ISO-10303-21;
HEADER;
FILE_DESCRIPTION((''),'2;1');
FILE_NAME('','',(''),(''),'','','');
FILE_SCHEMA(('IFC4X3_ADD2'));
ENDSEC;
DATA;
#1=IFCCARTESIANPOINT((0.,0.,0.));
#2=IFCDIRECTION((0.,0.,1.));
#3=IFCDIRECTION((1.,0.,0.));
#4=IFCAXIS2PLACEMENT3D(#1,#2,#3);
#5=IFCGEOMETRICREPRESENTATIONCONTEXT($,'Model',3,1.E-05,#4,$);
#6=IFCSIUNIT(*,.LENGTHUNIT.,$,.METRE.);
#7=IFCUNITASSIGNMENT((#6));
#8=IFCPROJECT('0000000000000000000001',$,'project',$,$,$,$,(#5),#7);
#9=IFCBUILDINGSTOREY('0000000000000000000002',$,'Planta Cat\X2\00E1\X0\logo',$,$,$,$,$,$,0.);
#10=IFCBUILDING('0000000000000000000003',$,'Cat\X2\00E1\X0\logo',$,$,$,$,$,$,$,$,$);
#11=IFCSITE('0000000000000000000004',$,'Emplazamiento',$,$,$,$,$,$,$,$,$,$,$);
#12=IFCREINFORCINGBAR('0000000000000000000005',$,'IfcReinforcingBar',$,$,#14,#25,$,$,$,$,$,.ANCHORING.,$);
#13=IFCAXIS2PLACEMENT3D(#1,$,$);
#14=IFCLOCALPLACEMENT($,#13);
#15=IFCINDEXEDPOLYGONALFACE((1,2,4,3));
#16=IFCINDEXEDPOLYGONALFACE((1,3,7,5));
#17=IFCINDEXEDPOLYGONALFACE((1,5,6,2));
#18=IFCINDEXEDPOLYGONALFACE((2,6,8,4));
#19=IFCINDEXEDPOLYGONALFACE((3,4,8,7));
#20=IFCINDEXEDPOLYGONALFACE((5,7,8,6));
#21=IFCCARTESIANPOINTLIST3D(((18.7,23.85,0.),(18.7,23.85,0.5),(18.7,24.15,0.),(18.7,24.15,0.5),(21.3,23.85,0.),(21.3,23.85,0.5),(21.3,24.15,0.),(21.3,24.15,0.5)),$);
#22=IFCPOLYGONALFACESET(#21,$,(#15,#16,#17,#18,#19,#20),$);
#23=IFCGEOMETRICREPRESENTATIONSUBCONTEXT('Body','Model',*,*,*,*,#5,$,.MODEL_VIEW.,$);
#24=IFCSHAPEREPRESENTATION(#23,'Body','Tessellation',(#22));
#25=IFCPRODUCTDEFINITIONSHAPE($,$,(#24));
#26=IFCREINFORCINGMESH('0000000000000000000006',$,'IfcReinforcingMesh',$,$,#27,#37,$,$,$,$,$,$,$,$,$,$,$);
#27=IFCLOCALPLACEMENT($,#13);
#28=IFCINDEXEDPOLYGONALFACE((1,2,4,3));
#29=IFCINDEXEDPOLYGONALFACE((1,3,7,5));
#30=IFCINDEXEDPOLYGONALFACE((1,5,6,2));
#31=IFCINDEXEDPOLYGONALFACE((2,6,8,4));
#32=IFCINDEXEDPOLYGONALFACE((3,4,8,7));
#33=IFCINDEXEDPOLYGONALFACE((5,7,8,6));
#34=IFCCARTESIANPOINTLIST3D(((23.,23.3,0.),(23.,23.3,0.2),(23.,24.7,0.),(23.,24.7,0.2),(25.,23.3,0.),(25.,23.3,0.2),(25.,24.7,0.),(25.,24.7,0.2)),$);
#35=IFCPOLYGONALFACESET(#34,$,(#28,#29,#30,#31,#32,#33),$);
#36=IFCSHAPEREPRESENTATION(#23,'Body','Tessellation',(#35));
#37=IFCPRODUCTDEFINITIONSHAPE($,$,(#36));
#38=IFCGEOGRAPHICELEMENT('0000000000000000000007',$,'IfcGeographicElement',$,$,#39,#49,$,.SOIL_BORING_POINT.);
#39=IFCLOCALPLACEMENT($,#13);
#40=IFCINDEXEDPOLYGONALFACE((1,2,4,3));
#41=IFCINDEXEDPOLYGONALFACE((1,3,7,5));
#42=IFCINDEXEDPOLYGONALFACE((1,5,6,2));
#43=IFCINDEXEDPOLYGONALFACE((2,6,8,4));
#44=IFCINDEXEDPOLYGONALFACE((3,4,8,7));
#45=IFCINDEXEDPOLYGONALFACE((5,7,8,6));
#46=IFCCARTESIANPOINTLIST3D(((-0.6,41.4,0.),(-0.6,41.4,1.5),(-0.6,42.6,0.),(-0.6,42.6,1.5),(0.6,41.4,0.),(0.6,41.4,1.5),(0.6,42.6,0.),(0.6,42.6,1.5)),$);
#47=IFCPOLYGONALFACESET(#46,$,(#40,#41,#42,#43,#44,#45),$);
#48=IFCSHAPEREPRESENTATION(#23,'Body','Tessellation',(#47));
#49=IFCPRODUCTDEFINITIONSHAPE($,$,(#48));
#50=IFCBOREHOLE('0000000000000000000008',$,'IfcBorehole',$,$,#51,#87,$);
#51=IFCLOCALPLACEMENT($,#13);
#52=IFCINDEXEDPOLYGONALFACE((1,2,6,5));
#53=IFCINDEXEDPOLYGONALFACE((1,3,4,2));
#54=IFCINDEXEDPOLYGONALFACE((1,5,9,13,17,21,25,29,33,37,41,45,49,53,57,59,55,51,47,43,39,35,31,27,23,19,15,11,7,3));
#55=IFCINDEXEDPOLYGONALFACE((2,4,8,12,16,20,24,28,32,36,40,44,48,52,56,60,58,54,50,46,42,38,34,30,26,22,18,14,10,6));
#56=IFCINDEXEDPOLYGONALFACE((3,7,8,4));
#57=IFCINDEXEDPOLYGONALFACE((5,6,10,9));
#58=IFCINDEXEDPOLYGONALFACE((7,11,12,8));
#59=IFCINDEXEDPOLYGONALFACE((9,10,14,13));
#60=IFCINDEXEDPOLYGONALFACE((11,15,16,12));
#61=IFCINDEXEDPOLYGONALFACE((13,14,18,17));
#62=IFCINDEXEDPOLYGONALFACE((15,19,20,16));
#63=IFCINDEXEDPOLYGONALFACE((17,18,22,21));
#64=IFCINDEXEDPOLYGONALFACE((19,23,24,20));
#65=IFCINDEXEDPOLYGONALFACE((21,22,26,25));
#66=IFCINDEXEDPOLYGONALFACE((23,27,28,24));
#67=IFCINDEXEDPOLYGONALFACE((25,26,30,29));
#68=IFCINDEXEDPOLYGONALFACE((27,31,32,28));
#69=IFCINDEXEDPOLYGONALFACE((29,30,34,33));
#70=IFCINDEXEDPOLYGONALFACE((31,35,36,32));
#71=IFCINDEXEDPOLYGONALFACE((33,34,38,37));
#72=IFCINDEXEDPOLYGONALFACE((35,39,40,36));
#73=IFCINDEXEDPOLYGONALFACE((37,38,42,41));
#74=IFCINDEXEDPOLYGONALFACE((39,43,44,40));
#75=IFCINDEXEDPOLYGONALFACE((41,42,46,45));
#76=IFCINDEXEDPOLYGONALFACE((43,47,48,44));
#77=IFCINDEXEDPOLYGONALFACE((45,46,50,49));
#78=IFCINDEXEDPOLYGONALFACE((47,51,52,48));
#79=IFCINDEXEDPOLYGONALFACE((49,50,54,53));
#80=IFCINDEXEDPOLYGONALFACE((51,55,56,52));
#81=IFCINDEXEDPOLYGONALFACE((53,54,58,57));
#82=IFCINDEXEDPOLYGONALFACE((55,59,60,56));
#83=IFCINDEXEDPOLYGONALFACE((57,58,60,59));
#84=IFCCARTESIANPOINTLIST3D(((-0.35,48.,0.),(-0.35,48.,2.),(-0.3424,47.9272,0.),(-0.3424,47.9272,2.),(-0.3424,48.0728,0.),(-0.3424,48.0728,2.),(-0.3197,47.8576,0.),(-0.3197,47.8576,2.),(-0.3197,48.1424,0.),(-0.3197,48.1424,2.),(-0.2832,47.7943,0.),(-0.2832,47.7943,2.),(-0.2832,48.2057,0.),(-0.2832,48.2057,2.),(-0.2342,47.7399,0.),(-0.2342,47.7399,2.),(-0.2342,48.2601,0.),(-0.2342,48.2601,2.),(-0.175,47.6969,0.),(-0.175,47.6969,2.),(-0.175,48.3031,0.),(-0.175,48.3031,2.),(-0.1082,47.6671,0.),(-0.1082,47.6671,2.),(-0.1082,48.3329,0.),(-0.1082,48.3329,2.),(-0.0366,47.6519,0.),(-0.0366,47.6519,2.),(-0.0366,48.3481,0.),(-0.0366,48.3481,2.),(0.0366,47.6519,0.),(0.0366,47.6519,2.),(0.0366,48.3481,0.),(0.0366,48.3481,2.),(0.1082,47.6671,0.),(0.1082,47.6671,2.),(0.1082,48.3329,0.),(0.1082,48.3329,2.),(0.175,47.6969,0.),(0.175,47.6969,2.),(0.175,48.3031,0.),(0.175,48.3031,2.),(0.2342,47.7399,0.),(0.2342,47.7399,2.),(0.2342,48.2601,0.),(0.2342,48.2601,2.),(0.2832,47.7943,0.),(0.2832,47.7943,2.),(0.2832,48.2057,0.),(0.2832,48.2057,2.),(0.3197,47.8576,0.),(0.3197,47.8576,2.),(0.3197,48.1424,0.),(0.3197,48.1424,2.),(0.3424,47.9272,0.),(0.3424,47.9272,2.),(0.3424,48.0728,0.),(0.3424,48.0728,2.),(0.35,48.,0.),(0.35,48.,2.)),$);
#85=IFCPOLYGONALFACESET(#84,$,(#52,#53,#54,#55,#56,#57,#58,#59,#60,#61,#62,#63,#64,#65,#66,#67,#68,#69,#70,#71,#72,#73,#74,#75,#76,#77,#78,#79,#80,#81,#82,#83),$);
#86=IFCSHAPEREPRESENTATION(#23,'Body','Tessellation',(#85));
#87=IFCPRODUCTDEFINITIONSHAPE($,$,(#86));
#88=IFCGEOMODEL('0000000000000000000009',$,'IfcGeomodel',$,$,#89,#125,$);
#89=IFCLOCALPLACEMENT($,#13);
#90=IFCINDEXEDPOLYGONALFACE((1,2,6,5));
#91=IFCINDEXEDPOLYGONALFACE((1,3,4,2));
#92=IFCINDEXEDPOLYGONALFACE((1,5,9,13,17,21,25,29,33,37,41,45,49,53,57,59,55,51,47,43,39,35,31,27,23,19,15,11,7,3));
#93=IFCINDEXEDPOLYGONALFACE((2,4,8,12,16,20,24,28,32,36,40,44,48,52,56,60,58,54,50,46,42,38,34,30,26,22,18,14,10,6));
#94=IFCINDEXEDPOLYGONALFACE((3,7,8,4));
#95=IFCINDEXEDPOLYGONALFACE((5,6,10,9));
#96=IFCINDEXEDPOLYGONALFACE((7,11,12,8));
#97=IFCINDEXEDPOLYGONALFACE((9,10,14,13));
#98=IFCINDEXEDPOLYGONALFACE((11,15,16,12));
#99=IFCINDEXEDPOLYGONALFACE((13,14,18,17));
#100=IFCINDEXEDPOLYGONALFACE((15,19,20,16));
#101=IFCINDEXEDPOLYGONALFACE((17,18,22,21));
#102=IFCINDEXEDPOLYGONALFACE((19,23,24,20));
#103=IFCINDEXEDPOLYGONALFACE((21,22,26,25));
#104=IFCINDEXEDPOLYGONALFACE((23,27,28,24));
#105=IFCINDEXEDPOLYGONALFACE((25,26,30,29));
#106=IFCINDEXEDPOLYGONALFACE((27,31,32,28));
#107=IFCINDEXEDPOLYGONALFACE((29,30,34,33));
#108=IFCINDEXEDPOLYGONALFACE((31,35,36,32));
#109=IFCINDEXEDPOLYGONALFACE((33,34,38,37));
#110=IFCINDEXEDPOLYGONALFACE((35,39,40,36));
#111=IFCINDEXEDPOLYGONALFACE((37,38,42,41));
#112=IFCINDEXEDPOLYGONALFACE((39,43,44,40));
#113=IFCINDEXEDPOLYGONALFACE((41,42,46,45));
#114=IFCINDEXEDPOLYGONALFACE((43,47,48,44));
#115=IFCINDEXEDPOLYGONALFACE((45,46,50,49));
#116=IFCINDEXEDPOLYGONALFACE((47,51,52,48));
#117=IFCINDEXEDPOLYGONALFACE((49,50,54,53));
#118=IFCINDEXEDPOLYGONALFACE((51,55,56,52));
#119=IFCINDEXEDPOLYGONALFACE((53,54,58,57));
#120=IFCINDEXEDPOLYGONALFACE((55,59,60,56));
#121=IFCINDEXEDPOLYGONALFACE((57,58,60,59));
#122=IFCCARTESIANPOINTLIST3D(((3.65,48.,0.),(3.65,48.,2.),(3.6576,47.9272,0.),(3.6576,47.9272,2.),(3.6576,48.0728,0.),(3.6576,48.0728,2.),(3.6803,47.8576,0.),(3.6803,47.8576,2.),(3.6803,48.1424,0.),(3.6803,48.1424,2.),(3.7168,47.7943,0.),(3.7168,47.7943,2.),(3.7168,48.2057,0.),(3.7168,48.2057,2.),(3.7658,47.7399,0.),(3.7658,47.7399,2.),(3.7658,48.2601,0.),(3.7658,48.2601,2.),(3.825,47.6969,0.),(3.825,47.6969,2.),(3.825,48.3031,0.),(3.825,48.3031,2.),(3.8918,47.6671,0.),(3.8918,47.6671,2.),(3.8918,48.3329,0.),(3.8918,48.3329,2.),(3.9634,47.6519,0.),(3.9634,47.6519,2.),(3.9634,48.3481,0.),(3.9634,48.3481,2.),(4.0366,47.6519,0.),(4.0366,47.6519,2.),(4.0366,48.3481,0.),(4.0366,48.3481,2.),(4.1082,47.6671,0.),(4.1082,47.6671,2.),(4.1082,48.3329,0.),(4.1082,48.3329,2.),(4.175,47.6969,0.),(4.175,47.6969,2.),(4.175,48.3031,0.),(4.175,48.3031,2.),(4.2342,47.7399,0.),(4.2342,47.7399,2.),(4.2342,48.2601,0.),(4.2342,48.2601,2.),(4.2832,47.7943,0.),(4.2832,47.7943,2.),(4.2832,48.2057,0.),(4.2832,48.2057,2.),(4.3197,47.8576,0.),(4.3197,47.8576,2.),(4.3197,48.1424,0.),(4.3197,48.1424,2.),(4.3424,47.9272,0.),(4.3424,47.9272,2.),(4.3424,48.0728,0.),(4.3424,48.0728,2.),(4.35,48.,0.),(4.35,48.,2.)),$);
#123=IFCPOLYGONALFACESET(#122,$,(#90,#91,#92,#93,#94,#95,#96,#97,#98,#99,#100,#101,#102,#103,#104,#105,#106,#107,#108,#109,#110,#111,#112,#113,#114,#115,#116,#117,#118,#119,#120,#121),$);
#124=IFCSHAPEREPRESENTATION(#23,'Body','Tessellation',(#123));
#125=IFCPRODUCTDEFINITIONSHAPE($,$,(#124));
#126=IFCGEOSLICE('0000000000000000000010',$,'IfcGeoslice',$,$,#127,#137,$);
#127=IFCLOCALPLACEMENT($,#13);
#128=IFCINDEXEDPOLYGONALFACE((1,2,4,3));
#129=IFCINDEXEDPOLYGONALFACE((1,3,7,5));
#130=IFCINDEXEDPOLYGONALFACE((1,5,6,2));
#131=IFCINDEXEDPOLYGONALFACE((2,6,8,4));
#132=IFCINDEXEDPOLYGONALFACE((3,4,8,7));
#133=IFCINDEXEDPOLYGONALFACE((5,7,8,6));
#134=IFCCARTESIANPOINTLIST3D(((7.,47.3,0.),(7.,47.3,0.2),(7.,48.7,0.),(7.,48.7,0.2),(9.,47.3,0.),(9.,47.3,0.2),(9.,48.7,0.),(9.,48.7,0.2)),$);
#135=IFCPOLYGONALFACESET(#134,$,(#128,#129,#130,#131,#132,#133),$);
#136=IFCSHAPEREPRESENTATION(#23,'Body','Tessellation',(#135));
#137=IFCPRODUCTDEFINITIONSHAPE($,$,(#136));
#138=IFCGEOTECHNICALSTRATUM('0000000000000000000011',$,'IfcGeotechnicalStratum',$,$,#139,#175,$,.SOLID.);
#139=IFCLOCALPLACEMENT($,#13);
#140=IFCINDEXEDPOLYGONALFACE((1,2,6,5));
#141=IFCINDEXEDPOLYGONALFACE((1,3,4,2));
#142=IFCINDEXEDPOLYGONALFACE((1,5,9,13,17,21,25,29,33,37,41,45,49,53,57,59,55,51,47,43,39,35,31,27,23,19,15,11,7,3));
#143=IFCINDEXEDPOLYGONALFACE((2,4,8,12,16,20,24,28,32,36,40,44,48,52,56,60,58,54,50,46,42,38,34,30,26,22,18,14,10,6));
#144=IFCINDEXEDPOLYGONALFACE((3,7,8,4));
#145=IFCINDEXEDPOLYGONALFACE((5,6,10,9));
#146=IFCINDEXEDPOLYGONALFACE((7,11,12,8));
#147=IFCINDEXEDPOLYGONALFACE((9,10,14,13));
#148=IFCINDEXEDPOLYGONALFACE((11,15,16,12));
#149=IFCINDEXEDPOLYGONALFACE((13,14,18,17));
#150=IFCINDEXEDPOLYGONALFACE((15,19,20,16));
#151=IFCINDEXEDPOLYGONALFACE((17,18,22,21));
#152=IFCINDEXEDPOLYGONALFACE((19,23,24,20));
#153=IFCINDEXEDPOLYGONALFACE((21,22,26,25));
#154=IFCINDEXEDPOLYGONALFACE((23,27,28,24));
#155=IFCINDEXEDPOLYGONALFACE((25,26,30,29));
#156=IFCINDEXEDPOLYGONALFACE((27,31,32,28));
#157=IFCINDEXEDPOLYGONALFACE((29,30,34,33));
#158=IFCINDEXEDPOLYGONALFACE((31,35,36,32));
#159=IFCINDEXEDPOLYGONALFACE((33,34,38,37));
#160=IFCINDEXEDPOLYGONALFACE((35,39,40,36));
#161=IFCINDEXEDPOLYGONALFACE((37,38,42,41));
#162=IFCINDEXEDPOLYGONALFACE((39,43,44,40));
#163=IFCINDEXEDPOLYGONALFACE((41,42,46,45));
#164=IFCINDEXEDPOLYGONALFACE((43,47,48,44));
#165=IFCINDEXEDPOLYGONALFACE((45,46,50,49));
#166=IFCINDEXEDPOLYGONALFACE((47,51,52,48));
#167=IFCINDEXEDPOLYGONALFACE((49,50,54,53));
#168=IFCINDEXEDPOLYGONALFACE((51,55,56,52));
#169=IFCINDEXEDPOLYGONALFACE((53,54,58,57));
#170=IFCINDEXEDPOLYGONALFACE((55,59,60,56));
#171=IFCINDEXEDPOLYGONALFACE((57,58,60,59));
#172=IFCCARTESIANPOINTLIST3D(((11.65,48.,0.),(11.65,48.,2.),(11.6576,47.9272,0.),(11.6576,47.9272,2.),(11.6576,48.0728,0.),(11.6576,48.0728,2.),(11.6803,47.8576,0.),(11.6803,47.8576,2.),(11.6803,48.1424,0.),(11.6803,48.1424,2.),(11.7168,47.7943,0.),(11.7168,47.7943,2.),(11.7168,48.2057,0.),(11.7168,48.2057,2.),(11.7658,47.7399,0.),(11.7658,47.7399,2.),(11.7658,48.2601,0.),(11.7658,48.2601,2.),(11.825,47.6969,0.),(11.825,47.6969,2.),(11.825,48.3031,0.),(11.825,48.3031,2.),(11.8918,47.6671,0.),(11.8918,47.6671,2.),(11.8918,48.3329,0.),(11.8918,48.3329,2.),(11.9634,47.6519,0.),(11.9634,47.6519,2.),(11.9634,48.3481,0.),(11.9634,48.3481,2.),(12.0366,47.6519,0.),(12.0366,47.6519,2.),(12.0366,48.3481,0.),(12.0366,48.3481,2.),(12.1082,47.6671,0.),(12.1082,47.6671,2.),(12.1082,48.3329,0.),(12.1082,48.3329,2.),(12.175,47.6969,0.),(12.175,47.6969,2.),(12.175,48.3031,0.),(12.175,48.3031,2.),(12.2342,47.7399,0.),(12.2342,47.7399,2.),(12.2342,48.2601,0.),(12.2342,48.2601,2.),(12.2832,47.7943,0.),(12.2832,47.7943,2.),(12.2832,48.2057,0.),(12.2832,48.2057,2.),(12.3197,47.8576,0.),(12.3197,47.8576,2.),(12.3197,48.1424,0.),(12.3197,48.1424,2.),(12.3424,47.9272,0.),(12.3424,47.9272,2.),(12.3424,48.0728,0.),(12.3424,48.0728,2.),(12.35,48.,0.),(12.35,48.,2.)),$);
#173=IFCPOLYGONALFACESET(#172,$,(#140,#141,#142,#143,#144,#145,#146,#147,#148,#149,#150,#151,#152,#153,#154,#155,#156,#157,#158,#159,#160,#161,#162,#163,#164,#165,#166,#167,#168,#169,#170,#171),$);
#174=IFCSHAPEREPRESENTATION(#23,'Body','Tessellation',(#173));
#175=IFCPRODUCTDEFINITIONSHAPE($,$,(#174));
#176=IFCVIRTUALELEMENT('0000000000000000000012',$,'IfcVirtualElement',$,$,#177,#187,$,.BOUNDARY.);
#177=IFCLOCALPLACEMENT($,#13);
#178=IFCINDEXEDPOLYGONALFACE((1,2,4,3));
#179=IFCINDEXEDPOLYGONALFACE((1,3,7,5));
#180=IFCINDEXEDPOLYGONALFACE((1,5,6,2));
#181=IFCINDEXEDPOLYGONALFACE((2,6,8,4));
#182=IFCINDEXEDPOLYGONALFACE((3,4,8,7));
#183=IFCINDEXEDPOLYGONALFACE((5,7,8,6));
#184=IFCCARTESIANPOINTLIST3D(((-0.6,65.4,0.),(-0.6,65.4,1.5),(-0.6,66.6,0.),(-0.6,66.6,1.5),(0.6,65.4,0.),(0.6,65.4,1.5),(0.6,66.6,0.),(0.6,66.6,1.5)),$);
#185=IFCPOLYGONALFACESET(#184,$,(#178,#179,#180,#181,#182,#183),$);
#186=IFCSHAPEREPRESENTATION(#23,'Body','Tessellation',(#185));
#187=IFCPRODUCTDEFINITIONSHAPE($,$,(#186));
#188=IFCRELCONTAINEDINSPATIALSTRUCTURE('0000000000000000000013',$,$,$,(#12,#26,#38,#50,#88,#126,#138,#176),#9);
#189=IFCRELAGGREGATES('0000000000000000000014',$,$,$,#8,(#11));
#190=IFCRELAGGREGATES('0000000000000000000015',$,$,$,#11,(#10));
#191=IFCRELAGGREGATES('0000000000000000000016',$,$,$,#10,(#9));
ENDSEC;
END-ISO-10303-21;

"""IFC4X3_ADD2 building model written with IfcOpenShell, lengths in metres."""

from ifc_helpers import new_model, si_unit, frame, origin, origin_with_axes, origin_2d, place, context, subcontext, project, spatial, rectangle, circle, extrude, element, save


model = new_model("IFC4X3_ADD2")

# Units and contexts
model_context = context("Model", 3, precision=1e-05, world=origin_with_axes())
body_context = subcontext(model_context, "Body", "Model", "MODEL_VIEW")
ifc_project = project(units=[si_unit("LENGTHUNIT", "METRE")], contexts=[model_context])

# Site, building, storey
site = spatial("IfcSite", under=ifc_project, Name="Emplazamiento")
building = spatial("IfcBuilding", under=site, Name="Catálogo")
storey = spatial("IfcBuildingStorey", under=building, Name="Planta Catálogo", Elevation=0.0)

# Reinforcing bar
reinforcing_bar_placement = place(None, frame((20.0, 24.0, 0.0), z_axis=(0.0, 0.0, 1.0), x_axis=(1.0, 0.0, 0.0)))
element("IfcReinforcingBar", 1, at=reinforcing_bar_placement, inside=storey, Name="IfcReinforcingBar", PredefinedType="ANCHORING", context=body_context, shape_type="SweptSolid", body=[
    extrude(rectangle(XDim=2.6, YDim=0.3, at=origin_2d()), origin(), (0.0, 0.0, 1.0), 0.5),
])

# Reinforcing mesh
reinforcing_mesh_placement = place(None, frame((24.0, 24.0, 0.0), z_axis=(0.0, 0.0, 1.0), x_axis=(1.0, 0.0, 0.0)))
element("IfcReinforcingMesh", 2, at=reinforcing_mesh_placement, inside=storey, Name="IfcReinforcingMesh", context=body_context, shape_type="SweptSolid", body=[
    extrude(rectangle(XDim=2.0, YDim=1.4, at=origin_2d()), origin(), (0.0, 0.0, 1.0), 0.2),
])

# Geographic element
geographic_element_placement = place(None, frame((0.0, 42.0, 0.0), z_axis=(0.0, 0.0, 1.0), x_axis=(1.0, 0.0, 0.0)))
element("IfcGeographicElement", 3, at=geographic_element_placement, inside=storey, Name="IfcGeographicElement", PredefinedType="SOIL_BORING_POINT", context=body_context, shape_type="SweptSolid", body=[
    extrude(rectangle(XDim=1.2, YDim=1.2, at=origin_2d()), origin(), (0.0, 0.0, 1.0), 1.5),
])

# Borehole
borehole_placement = place(None, frame((0.0, 48.0, 0.0), z_axis=(0.0, 0.0, 1.0), x_axis=(1.0, 0.0, 0.0)))
element("IfcBorehole", 4, at=borehole_placement, inside=storey, Name="IfcBorehole", context=body_context, shape_type="SweptSolid", body=[
    extrude(circle(Radius=0.35, at=origin_2d()), origin(), (0.0, 0.0, 1.0), 2.0),
])

# Geomodel
geomodel_placement = place(None, frame((4.0, 48.0, 0.0), z_axis=(0.0, 0.0, 1.0), x_axis=(1.0, 0.0, 0.0)))
element("IfcGeomodel", 5, at=geomodel_placement, inside=storey, Name="IfcGeomodel", context=body_context, shape_type="SweptSolid", body=[
    extrude(circle(Radius=0.35, at=origin_2d()), origin(), (0.0, 0.0, 1.0), 2.0),
])

# Geoslice
geoslice_placement = place(None, frame((8.0, 48.0, 0.0), z_axis=(0.0, 0.0, 1.0), x_axis=(1.0, 0.0, 0.0)))
element("IfcGeoslice", 6, at=geoslice_placement, inside=storey, Name="IfcGeoslice", context=body_context, shape_type="SweptSolid", body=[
    extrude(rectangle(XDim=2.0, YDim=1.4, at=origin_2d()), origin(), (0.0, 0.0, 1.0), 0.2),
])

# Geotechnical stratum
geotechnical_stratum_placement = place(None, frame((12.0, 48.0, 0.0), z_axis=(0.0, 0.0, 1.0), x_axis=(1.0, 0.0, 0.0)))
element("IfcGeotechnicalStratum", 7, at=geotechnical_stratum_placement, inside=storey, Name="IfcGeotechnicalStratum", PredefinedType="SOLID", context=body_context, shape_type="SweptSolid", body=[
    extrude(circle(Radius=0.35, at=origin_2d()), origin(), (0.0, 0.0, 1.0), 2.0),
])

# Virtual element
virtual_element_placement = place(None, frame((0.0, 66.0, 0.0), z_axis=(0.0, 0.0, 1.0), x_axis=(1.0, 0.0, 0.0)))
element("IfcVirtualElement", 8, at=virtual_element_placement, inside=storey, Name="IfcVirtualElement", PredefinedType="BOUNDARY", context=body_context, shape_type="SweptSolid", body=[
    extrude(rectangle(XDim=1.2, YDim=1.2, at=origin_2d()), origin(), (0.0, 0.0, 1.0), 1.5),
])

save(model, "model.ifc")
